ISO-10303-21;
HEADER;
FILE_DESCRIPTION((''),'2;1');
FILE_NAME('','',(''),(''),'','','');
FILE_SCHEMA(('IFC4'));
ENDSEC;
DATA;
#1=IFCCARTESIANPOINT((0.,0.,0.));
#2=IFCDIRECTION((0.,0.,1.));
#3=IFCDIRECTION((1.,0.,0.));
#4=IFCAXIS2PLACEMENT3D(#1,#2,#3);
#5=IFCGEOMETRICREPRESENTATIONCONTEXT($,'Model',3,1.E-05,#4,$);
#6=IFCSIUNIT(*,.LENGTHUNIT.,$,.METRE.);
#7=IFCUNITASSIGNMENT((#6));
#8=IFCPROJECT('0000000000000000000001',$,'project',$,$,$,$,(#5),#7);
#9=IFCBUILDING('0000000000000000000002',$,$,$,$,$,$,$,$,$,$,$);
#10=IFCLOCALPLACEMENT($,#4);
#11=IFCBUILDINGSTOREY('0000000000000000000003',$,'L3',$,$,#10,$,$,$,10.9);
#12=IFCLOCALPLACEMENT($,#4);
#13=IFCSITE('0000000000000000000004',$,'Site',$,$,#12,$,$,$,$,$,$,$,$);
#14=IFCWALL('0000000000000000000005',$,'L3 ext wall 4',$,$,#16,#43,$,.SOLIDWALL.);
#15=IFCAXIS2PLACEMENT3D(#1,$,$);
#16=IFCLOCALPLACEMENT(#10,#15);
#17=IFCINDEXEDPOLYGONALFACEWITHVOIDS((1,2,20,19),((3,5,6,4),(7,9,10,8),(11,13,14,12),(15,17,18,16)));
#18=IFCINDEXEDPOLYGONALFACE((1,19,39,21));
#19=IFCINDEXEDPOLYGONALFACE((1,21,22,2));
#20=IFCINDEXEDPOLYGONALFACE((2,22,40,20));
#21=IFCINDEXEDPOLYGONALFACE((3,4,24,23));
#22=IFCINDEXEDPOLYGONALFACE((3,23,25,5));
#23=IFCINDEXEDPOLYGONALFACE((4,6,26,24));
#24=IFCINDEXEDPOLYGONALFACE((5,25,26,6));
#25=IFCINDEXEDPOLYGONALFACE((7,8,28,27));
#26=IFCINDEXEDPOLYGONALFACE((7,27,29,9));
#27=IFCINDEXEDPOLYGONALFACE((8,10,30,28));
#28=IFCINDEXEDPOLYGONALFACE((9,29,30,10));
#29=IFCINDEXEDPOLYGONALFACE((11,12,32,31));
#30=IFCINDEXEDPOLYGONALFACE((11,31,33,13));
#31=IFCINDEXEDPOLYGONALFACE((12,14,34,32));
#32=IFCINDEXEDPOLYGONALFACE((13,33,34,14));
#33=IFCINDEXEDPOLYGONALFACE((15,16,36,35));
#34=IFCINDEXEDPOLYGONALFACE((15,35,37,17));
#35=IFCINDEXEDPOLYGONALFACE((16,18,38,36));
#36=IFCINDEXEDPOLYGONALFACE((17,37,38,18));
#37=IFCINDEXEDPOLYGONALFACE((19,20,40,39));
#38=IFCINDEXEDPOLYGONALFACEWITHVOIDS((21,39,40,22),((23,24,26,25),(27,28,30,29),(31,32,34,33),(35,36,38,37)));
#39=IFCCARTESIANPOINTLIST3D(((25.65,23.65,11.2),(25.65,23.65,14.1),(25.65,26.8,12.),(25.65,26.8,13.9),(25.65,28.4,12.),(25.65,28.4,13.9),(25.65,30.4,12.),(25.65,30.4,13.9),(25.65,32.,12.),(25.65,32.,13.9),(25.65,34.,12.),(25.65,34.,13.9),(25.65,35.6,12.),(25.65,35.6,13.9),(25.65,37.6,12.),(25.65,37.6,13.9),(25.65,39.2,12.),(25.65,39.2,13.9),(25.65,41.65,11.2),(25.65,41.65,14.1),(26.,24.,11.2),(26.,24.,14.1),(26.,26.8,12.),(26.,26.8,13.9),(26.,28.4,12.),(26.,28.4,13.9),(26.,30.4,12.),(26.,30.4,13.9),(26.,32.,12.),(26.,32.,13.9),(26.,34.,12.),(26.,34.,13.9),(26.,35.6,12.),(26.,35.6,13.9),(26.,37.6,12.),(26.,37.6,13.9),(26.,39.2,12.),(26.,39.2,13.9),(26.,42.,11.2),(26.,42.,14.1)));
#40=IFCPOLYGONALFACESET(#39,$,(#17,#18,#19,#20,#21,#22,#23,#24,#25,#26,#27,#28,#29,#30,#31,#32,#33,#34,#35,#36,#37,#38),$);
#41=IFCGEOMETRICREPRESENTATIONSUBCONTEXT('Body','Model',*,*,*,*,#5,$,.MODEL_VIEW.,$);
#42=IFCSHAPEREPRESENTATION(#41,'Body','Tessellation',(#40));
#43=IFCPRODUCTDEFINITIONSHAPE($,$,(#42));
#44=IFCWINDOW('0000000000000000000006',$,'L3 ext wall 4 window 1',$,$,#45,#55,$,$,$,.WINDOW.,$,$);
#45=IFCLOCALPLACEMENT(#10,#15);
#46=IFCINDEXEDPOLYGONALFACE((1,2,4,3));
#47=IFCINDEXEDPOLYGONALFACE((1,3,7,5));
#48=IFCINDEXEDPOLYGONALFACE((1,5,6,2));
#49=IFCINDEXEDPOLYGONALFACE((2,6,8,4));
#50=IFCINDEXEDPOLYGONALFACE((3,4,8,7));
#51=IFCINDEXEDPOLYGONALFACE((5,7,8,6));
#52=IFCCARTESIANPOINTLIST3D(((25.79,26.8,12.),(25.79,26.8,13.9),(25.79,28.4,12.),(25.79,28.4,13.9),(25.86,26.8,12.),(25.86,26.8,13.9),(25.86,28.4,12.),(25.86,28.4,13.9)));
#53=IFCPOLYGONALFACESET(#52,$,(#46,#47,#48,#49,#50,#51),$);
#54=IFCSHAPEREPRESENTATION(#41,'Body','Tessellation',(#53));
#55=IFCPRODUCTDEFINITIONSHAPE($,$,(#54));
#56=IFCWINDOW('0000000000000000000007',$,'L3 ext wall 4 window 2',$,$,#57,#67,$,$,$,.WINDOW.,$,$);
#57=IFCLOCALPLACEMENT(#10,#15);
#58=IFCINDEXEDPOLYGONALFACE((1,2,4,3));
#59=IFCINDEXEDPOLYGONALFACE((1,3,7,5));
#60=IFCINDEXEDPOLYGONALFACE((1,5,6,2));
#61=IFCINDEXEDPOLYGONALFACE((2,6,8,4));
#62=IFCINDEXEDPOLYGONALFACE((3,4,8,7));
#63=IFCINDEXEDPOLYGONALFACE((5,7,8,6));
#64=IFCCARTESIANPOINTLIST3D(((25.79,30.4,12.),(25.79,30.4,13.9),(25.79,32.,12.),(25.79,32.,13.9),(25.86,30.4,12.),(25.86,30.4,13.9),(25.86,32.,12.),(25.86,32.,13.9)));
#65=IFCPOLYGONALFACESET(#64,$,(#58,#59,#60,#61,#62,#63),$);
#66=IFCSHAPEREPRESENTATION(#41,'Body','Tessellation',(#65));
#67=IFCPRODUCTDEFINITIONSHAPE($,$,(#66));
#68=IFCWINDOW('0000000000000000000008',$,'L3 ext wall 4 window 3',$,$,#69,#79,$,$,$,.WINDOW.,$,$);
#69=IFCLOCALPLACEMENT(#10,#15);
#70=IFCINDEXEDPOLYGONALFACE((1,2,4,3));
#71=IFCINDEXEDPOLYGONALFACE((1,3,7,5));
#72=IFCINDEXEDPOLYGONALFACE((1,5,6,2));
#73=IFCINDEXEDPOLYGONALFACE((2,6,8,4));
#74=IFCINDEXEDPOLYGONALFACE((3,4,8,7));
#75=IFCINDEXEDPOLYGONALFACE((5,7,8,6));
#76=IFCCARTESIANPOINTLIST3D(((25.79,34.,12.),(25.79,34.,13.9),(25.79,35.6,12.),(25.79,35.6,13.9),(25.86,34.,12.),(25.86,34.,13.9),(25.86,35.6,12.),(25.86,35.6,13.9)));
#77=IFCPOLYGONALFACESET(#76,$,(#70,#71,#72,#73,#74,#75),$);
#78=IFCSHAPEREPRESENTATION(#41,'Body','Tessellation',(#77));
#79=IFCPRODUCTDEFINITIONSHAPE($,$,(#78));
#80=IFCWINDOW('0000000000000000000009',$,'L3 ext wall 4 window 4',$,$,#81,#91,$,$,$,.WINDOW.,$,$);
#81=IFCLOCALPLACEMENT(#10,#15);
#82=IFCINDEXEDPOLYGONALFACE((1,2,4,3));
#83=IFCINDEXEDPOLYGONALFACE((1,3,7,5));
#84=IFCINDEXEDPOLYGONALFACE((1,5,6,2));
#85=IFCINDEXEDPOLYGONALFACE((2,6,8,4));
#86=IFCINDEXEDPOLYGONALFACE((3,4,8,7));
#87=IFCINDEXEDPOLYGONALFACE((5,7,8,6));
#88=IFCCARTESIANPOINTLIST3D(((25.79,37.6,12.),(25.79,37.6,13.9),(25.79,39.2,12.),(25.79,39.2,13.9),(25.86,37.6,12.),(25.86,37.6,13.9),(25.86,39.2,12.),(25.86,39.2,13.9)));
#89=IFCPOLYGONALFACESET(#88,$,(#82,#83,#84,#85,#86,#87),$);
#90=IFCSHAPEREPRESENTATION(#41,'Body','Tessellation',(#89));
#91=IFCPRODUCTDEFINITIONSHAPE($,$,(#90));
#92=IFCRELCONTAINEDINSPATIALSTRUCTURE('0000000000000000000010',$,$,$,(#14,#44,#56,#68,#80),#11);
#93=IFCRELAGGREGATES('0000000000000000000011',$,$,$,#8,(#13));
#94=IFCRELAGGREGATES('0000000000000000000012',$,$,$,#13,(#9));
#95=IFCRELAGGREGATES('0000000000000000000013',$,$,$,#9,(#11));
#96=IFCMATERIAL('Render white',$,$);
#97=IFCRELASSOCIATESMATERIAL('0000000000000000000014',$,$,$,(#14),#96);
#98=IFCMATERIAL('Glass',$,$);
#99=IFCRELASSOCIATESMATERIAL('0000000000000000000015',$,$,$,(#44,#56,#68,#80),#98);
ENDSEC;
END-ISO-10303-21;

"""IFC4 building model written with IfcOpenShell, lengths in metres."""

from ifc_helpers import new_model, si_unit, frame, origin_with_axes, place, context, subcontext, project, spatial, polyline, outline, extrude, material, element, fill, save


model = new_model("IFC4")

# Units and contexts
model_context = context("Model", 3, precision=1e-05, world=origin_with_axes())
body_context = subcontext(model_context, "Body", "Model", "MODEL_VIEW")
ifc_project = project(units=[si_unit("LENGTHUNIT", "METRE")], contexts=[model_context])

# Site, building, storey
site_placement = place(None, origin_with_axes())
site = spatial("IfcSite", under=ifc_project, at=site_placement, Name="Site")
building = spatial("IfcBuilding", under=site)
storey_placement = place(None, origin_with_axes())
storey = spatial("IfcBuildingStorey", under=building, at=storey_placement, Name="L3", Elevation=10.9)

# Wall, openings, windows
ifc_material_1 = material(Name="Render white")
ifc_material_2 = material(Name="Glass")
wall_1_placement = place(storey_placement, origin_with_axes())
wall_1 = element("IfcWall", 1, at=wall_1_placement, inside=storey, material=ifc_material_1, Name="L3 ext wall 4", PredefinedType="SOLIDWALL", context=body_context, shape_type="SweptSolid", body=[
    extrude(outline(polyline([(26.0, 24.0), (26.0, 42.0), (25.65, 41.65), (25.65, 23.65), (26.0, 24.0)])), frame((0.0, 0.0, 11.2), z_axis=(0.0, 0.0, 1.0), x_axis=(1.0, 0.0, 0.0)), (0.0, 0.0, 1.0), 2.9),
])
opening_1_placement = place(wall_1_placement, origin_with_axes())
opening_1 = element("IfcOpeningElement", 2, at=opening_1_placement, cuts=wall_1, context=body_context, shape_type="SweptSolid", body=[
    extrude(outline(polyline([(26.05, 26.8), (26.05, 28.4), (25.6, 28.4), (25.6, 26.8), (26.05, 26.8)])), frame((0.0, 0.0, 12.0), z_axis=(0.0, 0.0, 1.0), x_axis=(1.0, 0.0, 0.0)), (0.0, 0.0, 1.0), 1.9),
])
opening_2_placement = place(wall_1_placement, origin_with_axes())
opening_2 = element("IfcOpeningElement", 3, at=opening_2_placement, cuts=wall_1, context=body_context, shape_type="SweptSolid", body=[
    extrude(outline(polyline([(26.05, 30.4), (26.05, 32.0), (25.6, 32.0), (25.6, 30.4), (26.05, 30.4)])), frame((0.0, 0.0, 12.0), z_axis=(0.0, 0.0, 1.0), x_axis=(1.0, 0.0, 0.0)), (0.0, 0.0, 1.0), 1.9),
])
opening_3_placement = place(wall_1_placement, origin_with_axes())
opening_3 = element("IfcOpeningElement", 4, at=opening_3_placement, cuts=wall_1, context=body_context, shape_type="SweptSolid", body=[
    extrude(outline(polyline([(26.05, 34.0), (26.05, 35.6), (25.6, 35.6), (25.6, 34.0), (26.05, 34.0)])), frame((0.0, 0.0, 12.0), z_axis=(0.0, 0.0, 1.0), x_axis=(1.0, 0.0, 0.0)), (0.0, 0.0, 1.0), 1.9),
])
opening_4_placement = place(wall_1_placement, origin_with_axes())
opening_4 = element("IfcOpeningElement", 5, at=opening_4_placement, cuts=wall_1, context=body_context, shape_type="SweptSolid", body=[
    extrude(outline(polyline([(26.05, 37.6), (26.05, 39.2), (25.6, 39.2), (25.6, 37.6), (26.05, 37.6)])), frame((0.0, 0.0, 12.0), z_axis=(0.0, 0.0, 1.0), x_axis=(1.0, 0.0, 0.0)), (0.0, 0.0, 1.0), 1.9),
])
window_1_placement = place(storey_placement, origin_with_axes())
window_1 = element("IfcWindow", 6, at=window_1_placement, inside=storey, material=ifc_material_2, Name="L3 ext wall 4 window 1", PredefinedType="WINDOW", context=body_context, shape_type="SweptSolid", body=[
    extrude(outline(polyline([(25.86, 26.8), (25.86, 28.4), (25.79, 28.4), (25.79, 26.8), (25.86, 26.8)])), frame((0.0, 0.0, 12.0), z_axis=(0.0, 0.0, 1.0), x_axis=(1.0, 0.0, 0.0)), (0.0, 0.0, 1.0), 1.9),
])
fill(opening_1, window_1)
window_2_placement = place(storey_placement, origin_with_axes())
window_2 = element("IfcWindow", 7, at=window_2_placement, inside=storey, material=ifc_material_2, Name="L3 ext wall 4 window 2", PredefinedType="WINDOW", context=body_context, shape_type="SweptSolid", body=[
    extrude(outline(polyline([(25.86, 30.4), (25.86, 32.0), (25.79, 32.0), (25.79, 30.4), (25.86, 30.4)])), frame((0.0, 0.0, 12.0), z_axis=(0.0, 0.0, 1.0), x_axis=(1.0, 0.0, 0.0)), (0.0, 0.0, 1.0), 1.9),
])
fill(opening_2, window_2)
window_3_placement = place(storey_placement, origin_with_axes())
window_3 = element("IfcWindow", 8, at=window_3_placement, inside=storey, material=ifc_material_2, Name="L3 ext wall 4 window 3", PredefinedType="WINDOW", context=body_context, shape_type="SweptSolid", body=[
    extrude(outline(polyline([(25.86, 34.0), (25.86, 35.6), (25.79, 35.6), (25.79, 34.0), (25.86, 34.0)])), frame((0.0, 0.0, 12.0), z_axis=(0.0, 0.0, 1.0), x_axis=(1.0, 0.0, 0.0)), (0.0, 0.0, 1.0), 1.9),
])
fill(opening_3, window_3)
window_4_placement = place(storey_placement, origin_with_axes())
window_4 = element("IfcWindow", 9, at=window_4_placement, inside=storey, material=ifc_material_2, Name="L3 ext wall 4 window 4", PredefinedType="WINDOW", context=body_context, shape_type="SweptSolid", body=[
    extrude(outline(polyline([(25.86, 37.6), (25.86, 39.2), (25.79, 39.2), (25.79, 37.6), (25.86, 37.6)])), frame((0.0, 0.0, 12.0), z_axis=(0.0, 0.0, 1.0), x_axis=(1.0, 0.0, 0.0)), (0.0, 0.0, 1.0), 1.9),
])
fill(opening_4, window_4)

save(model, "model.ifc")
